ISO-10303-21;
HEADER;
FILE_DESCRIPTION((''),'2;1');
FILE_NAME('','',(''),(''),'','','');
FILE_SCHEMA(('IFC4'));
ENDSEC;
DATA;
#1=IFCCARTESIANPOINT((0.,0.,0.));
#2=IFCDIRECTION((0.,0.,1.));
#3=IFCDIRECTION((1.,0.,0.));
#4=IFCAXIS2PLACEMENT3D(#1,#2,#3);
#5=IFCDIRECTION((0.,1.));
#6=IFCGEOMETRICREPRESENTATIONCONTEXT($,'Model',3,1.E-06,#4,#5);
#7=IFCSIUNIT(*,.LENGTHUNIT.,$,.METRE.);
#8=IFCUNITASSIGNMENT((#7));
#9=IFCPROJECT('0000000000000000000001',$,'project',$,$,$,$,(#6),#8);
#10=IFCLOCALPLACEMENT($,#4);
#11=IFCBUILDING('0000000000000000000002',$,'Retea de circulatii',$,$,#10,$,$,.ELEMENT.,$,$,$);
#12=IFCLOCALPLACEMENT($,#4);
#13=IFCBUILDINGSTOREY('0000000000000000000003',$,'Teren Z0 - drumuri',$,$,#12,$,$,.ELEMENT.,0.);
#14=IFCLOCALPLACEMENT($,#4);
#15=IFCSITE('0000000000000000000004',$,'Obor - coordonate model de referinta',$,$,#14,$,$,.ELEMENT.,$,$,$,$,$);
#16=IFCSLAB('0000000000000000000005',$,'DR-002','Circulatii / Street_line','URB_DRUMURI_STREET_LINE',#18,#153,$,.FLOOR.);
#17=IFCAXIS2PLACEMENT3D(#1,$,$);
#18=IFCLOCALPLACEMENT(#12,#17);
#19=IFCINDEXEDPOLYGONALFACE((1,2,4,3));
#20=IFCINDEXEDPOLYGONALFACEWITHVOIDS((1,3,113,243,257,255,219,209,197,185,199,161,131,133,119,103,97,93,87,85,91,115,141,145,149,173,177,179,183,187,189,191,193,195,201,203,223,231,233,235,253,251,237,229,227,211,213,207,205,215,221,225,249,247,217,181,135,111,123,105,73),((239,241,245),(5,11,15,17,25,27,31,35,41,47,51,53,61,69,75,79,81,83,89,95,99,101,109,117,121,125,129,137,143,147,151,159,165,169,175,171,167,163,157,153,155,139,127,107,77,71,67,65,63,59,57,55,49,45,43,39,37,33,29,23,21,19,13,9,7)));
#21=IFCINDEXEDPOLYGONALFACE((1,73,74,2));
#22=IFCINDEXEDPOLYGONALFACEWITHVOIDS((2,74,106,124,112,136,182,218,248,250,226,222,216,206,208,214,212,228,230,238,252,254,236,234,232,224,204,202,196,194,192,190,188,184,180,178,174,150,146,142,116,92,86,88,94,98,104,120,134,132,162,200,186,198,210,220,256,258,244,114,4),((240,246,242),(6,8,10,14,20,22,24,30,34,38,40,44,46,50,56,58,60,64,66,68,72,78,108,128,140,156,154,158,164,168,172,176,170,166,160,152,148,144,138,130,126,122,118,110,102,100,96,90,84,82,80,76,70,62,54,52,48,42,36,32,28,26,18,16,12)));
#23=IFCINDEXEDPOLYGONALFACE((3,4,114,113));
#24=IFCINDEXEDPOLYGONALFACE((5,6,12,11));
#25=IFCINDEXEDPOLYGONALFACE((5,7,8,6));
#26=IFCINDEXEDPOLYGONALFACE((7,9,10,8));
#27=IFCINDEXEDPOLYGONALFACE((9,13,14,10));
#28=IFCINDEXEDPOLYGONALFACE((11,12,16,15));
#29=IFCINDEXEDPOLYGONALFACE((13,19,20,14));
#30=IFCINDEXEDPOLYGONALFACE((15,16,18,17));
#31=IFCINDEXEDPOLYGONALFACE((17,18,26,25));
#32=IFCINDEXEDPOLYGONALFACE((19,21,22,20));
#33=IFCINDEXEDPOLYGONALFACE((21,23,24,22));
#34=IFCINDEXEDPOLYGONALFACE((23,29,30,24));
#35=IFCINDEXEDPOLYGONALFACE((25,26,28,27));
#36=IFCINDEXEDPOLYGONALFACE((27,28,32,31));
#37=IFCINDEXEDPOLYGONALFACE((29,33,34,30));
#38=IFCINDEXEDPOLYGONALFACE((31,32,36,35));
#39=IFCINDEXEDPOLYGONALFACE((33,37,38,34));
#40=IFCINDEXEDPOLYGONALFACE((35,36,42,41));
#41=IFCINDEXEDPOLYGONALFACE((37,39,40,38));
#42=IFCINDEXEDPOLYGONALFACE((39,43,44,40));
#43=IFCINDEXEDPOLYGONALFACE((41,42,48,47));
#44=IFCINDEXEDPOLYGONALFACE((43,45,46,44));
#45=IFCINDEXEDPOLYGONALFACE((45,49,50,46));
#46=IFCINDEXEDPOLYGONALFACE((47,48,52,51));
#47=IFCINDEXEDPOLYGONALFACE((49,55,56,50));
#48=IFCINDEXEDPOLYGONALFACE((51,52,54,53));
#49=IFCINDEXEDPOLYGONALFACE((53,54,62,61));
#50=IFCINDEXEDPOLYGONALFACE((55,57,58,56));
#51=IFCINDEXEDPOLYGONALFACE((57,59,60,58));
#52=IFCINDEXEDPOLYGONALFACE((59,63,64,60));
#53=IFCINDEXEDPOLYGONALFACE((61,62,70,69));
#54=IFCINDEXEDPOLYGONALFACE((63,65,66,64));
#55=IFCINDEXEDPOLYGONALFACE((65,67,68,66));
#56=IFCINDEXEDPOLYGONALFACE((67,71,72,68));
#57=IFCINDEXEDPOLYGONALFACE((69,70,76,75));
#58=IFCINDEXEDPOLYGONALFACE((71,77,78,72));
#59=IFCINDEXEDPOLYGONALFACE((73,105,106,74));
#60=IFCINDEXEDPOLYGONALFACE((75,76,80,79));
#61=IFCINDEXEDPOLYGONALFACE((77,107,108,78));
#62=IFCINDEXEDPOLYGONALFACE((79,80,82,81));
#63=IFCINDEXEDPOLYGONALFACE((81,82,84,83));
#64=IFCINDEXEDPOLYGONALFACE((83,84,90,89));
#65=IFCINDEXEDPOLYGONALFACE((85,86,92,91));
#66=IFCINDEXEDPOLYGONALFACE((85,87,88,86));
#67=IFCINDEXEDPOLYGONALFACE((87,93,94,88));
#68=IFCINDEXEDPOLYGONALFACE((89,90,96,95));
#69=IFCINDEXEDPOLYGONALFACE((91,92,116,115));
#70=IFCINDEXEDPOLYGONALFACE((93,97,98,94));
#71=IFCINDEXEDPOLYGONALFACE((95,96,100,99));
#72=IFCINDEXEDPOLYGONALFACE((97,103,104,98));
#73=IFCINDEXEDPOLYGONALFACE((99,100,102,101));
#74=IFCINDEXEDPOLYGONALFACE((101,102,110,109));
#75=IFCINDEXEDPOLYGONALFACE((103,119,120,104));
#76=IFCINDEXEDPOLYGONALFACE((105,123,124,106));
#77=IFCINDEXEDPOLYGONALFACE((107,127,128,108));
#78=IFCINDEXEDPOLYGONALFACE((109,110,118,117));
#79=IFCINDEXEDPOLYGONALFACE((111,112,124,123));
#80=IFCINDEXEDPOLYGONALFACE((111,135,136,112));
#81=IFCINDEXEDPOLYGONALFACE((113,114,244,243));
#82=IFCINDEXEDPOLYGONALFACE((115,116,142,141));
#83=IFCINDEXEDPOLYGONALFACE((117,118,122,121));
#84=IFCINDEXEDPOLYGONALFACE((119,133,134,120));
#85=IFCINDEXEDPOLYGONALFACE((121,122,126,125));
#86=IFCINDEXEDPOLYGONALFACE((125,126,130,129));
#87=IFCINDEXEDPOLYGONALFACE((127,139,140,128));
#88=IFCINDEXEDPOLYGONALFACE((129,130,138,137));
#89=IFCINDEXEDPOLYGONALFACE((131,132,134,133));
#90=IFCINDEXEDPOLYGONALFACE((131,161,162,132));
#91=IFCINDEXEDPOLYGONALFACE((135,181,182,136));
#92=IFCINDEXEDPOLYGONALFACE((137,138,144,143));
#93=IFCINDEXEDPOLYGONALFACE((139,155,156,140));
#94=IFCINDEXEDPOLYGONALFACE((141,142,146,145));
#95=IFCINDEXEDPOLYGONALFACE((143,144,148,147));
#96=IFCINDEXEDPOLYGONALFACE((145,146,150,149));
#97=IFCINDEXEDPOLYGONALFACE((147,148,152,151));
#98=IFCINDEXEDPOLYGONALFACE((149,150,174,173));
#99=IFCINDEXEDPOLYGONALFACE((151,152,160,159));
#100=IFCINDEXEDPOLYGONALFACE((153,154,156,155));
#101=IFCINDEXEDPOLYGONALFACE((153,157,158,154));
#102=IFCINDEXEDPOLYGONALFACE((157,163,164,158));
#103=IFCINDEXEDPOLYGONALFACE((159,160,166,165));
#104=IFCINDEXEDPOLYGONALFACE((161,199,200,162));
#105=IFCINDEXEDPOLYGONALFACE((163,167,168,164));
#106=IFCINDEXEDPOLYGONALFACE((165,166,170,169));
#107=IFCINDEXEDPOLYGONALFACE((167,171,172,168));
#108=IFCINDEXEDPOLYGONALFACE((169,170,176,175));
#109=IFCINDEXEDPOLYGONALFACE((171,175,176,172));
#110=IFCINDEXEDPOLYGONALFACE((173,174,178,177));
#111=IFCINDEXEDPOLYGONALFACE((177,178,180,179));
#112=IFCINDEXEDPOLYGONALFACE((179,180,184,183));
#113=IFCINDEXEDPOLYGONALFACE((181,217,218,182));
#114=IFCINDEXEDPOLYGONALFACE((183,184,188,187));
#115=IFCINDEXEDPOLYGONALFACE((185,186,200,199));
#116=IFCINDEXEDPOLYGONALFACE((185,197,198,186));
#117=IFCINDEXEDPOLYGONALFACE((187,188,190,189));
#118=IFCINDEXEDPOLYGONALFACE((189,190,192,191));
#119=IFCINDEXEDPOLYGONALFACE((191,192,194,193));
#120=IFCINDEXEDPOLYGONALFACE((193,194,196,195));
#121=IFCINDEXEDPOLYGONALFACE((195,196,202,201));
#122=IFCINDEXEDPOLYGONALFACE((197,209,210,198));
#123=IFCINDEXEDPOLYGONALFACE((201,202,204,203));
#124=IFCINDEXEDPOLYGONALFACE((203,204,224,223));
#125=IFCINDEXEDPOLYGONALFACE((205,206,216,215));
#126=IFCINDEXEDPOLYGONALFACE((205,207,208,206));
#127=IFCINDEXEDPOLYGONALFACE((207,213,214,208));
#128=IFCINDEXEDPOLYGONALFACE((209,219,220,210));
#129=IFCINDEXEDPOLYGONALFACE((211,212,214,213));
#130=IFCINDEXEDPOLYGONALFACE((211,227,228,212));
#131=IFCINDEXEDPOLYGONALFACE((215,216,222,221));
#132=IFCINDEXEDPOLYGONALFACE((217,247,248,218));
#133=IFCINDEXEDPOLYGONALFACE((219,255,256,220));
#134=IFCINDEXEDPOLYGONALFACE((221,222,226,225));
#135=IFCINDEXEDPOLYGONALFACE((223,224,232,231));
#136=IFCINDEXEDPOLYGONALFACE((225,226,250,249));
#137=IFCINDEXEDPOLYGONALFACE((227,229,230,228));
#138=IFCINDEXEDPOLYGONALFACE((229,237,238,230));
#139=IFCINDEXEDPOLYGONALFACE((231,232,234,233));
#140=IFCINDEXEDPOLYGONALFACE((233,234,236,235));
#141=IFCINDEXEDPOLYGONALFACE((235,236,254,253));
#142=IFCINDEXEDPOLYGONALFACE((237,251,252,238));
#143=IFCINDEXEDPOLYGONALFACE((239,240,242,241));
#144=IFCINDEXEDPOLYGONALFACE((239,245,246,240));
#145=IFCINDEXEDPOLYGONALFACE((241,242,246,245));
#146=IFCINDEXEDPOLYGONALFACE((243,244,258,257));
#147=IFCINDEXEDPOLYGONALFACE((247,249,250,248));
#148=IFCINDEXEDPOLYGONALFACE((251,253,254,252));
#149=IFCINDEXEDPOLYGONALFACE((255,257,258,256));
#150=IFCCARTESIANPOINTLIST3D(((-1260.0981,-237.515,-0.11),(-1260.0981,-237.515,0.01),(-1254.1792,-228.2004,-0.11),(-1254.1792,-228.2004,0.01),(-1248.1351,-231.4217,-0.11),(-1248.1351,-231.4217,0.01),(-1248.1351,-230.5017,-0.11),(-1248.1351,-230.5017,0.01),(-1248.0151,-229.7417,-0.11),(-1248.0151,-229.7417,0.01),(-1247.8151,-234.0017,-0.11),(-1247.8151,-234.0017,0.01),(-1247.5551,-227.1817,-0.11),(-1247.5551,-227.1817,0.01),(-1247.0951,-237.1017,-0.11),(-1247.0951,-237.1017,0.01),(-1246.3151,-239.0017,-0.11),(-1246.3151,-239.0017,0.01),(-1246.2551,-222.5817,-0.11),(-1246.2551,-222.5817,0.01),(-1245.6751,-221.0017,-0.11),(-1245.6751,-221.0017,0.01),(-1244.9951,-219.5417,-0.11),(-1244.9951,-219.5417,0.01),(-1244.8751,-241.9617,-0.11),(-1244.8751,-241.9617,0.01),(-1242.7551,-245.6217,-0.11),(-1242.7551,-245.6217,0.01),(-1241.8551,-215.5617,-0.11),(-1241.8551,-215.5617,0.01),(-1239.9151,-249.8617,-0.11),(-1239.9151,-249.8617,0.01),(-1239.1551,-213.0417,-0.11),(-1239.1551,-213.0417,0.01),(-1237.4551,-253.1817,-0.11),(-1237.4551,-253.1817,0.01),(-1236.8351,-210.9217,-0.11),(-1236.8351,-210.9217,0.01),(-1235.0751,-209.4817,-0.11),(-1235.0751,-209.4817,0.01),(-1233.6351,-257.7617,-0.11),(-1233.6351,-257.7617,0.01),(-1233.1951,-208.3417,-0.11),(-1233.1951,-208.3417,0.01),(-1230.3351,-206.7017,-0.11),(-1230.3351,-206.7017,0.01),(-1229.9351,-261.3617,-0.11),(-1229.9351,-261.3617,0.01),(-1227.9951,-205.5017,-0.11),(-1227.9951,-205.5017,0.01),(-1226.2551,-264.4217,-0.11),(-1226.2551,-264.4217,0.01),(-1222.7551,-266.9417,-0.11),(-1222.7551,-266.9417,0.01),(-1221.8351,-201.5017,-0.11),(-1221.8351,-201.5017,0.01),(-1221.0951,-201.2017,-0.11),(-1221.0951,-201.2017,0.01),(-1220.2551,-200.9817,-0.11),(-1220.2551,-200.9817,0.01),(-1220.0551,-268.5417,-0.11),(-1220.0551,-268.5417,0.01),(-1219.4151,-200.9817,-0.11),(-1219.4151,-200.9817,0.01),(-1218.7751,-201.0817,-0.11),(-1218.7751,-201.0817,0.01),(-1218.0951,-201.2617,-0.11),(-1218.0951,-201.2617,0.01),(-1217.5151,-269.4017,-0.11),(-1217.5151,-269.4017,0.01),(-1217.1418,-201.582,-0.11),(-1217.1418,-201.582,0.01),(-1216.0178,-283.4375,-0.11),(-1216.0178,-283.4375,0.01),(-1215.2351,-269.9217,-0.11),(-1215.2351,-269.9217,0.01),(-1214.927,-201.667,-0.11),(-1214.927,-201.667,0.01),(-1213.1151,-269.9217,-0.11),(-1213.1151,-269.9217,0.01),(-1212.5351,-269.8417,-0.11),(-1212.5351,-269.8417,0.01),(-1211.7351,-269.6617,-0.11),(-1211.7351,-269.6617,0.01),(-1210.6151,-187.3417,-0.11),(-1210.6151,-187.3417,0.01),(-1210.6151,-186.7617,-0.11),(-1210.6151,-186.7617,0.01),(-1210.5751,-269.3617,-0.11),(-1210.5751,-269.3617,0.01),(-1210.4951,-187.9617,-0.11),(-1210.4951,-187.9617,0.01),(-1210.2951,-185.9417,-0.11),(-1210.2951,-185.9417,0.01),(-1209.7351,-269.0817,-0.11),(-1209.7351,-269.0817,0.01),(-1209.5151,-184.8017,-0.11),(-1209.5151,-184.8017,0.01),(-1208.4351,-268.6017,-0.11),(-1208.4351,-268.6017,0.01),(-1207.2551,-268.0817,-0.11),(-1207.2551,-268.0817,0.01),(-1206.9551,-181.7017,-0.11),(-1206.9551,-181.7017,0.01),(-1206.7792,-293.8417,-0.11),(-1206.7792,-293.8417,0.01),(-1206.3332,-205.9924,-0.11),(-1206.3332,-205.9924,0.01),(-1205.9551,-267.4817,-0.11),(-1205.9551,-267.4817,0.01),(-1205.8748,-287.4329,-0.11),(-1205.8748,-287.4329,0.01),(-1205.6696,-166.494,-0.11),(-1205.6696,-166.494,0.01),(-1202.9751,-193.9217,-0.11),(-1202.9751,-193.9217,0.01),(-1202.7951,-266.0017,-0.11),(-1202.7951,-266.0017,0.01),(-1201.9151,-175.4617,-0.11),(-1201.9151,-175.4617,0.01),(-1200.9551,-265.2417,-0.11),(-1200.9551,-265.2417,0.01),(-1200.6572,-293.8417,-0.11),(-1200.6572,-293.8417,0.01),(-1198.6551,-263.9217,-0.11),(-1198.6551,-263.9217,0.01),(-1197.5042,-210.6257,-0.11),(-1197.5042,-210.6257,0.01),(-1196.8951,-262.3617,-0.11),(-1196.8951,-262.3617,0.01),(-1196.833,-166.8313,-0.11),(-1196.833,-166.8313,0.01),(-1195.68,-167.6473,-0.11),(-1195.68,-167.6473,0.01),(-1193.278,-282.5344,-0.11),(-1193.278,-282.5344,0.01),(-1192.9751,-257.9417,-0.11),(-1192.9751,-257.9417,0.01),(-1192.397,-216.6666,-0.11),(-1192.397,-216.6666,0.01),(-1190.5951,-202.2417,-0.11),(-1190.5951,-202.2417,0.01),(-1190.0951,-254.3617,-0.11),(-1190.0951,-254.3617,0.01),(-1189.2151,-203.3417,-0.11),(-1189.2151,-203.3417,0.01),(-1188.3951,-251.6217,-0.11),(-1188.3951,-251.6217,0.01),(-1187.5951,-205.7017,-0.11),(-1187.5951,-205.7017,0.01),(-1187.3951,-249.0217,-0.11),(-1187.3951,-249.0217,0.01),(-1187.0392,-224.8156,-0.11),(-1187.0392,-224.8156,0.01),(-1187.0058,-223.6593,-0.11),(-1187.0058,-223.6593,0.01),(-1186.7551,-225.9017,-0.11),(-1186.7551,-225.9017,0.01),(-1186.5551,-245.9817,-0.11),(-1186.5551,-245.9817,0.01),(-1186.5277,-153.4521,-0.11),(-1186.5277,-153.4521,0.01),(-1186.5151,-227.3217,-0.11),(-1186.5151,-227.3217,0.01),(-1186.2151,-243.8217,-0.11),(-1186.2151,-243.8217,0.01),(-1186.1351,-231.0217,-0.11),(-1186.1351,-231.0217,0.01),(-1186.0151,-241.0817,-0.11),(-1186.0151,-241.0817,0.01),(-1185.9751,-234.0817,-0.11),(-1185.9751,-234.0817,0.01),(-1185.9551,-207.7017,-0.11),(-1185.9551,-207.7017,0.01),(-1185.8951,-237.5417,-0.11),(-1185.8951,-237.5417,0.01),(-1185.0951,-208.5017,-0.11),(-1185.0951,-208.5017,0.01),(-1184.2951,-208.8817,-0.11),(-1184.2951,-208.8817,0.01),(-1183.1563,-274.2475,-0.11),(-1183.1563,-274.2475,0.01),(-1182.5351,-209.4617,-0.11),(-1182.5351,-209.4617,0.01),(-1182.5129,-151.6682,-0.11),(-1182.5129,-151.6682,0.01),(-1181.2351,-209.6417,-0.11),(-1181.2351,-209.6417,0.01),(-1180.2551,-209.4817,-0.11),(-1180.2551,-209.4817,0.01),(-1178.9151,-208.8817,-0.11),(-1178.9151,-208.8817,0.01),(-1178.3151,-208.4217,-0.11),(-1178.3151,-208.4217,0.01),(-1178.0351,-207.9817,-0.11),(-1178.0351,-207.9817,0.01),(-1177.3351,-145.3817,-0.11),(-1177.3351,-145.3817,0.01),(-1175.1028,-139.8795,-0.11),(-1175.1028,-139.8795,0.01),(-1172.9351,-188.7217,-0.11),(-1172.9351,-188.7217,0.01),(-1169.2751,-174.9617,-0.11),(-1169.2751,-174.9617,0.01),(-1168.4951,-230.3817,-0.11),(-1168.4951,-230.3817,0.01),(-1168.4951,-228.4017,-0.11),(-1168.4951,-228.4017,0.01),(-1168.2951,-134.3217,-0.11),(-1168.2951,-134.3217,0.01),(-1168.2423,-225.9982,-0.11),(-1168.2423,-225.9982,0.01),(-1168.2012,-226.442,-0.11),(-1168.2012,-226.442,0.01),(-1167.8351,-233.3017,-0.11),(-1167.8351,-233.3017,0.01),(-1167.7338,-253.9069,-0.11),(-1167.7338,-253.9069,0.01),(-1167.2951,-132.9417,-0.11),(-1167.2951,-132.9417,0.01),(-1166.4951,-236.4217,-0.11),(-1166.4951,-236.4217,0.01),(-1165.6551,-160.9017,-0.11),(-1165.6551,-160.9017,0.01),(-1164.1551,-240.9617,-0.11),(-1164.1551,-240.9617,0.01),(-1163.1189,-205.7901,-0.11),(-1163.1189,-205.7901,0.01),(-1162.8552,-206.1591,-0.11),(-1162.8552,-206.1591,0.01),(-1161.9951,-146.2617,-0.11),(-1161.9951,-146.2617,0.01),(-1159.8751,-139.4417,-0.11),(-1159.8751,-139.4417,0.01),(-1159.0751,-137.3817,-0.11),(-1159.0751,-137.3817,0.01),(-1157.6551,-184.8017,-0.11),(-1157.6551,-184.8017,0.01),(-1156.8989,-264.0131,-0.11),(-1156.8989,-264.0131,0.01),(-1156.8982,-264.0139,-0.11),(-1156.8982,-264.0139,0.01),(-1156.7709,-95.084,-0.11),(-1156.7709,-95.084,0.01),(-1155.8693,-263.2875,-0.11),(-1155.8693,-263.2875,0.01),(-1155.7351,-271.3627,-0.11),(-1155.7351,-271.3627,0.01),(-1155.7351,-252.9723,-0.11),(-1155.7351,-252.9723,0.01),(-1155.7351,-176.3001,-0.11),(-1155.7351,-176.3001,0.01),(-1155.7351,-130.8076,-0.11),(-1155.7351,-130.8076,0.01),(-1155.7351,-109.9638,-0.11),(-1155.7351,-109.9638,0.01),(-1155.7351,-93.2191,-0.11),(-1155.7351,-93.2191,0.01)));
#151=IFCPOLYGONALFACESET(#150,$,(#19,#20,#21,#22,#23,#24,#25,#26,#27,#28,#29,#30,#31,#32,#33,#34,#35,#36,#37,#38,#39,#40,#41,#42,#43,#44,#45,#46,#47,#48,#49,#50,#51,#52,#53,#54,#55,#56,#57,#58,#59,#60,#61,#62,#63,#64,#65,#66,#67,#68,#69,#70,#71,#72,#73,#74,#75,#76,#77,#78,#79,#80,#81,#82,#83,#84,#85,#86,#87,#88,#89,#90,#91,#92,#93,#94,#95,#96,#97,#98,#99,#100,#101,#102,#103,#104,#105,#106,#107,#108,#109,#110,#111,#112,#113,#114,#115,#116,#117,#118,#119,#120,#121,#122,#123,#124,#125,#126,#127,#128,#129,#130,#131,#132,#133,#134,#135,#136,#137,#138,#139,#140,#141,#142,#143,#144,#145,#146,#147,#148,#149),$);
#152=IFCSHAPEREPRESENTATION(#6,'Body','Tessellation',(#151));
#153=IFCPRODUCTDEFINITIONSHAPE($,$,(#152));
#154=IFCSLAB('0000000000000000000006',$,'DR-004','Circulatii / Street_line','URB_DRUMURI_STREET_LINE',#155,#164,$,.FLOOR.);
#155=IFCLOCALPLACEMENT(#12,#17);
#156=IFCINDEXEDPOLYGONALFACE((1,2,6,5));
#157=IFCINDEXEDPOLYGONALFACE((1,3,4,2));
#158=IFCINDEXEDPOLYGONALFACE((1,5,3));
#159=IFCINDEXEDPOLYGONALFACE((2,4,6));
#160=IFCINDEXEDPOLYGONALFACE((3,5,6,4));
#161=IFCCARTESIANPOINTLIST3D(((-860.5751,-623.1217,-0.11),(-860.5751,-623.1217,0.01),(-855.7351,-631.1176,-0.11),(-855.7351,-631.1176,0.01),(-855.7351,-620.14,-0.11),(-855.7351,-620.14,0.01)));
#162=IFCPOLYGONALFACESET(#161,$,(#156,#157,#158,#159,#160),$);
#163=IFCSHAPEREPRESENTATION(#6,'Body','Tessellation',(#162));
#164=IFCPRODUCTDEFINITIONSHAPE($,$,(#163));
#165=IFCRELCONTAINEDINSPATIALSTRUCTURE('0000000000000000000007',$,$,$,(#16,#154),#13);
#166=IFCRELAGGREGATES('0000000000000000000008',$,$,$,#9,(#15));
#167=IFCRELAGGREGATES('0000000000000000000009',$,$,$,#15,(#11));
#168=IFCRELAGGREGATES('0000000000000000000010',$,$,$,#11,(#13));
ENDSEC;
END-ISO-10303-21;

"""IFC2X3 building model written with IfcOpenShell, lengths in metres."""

from ifc_helpers import new_model, si_unit, direction, frame, origin_with_axes, place, context, project, spatial, polyline, outline, extrude, element, save


model = new_model("IFC2X3")

# Units and contexts
model_context = context("Model", 3, precision=1e-06, world=origin_with_axes(), true_north=direction((0.0, 1.0)))
ifc_project = project(units=[si_unit("LENGTHUNIT", "METRE")], contexts=[model_context])

# Site, building, storey
site_placement = place(None, origin_with_axes())
site = spatial("IfcSite", under=ifc_project, at=site_placement, Name="Obor - coordonate model de referinta", CompositionType="ELEMENT")
building_placement = place(None, origin_with_axes())
building = spatial("IfcBuilding", under=site, at=building_placement, Name="Retea de circulatii", CompositionType="ELEMENT")
storey_placement = place(None, origin_with_axes())
storey = spatial("IfcBuildingStorey", under=building, at=storey_placement, Name="Teren Z0 - drumuri", CompositionType="ELEMENT", Elevation=0.0)

# Slabs
slab_1_placement = place(None, origin_with_axes())
element("IfcSlab", 1, at=slab_1_placement, inside=storey, Name="DR-002", Description="Circulatii / Street_line", ObjectType="URB_DRUMURI_STREET_LINE", PredefinedType="FLOOR", context=model_context, shape_type="SweptSolid", body=[
    extrude(outline(polyline([(-1216.0178, -283.4375), (-1206.7792, -293.8417), (-1200.6572, -293.8417), (-1205.8748, -287.4329), (-1193.278, -282.5344), (-1183.1563, -274.2475), (-1167.7338, -253.9069), (-1155.7351, -271.3627), (-1155.7351, -252.9723), (-1164.1551, -240.9617), (-1166.4951, -236.4217), (-1167.8351, -233.3017), (-1168.4951, -230.3817), (-1168.4951, -228.4017), (-1168.2012, -226.442), (-1168.2423, -225.9982), (-1163.1189, -205.7901), (-1162.8552, -206.1591), (-1157.6551, -184.8017), (-1155.7351, -176.3001), (-1155.7351, -130.8076), (-1159.0751, -137.3817), (-1159.8751, -139.4417), (-1161.9951, -146.2617), (-1165.6551, -160.9017), (-1169.2751, -174.9617), (-1172.9351, -188.7217), (-1178.0351, -207.9817), (-1178.3151, -208.4217), (-1178.9151, -208.8817), (-1180.2551, -209.4817), (-1181.2351, -209.6417), (-1182.5351, -209.4617), (-1184.2951, -208.8817), (-1185.0951, -208.5017), (-1185.9551, -207.7017), (-1187.5951, -205.7017), (-1189.2151, -203.3417), (-1190.5951, -202.2417), (-1202.9751, -193.9217), (-1210.4951, -187.9617), (-1210.6151, -187.3417), (-1210.6151, -186.7617), (-1210.2951, -185.9417), (-1209.5151, -184.8017), (-1206.9551, -181.7017), (-1201.9151, -175.4617), (-1195.68, -167.6473), (-1196.833, -166.8313), (-1186.5277, -153.4521), (-1175.1028, -139.8795), (-1182.5129, -151.6682), (-1177.3351, -145.3817), (-1168.2951, -134.3217), (-1167.2951, -132.9417), (-1155.7351, -109.9638), (-1155.7351, -93.2191), (-1156.7709, -95.084), (-1205.6696, -166.494), (-1254.1792, -228.2004), (-1260.0981, -237.515), (-1216.0178, -283.4375)]), holes=[polyline([(-1186.0151, -241.0817), (-1186.2151, -243.8217), (-1186.5551, -245.9817), (-1187.3951, -249.0217), (-1188.3951, -251.6217), (-1190.0951, -254.3617), (-1192.9751, -257.9417), (-1196.8951, -262.3617), (-1198.6551, -263.9217), (-1200.9551, -265.2417), (-1200.9551, -265.2417), (-1202.7951, -266.0017), (-1205.9551, -267.4817), (-1207.2551, -268.0817), (-1208.4351, -268.6017), (-1209.7351, -269.0817), (-1210.5751, -269.3617), (-1211.7351, -269.6617), (-1212.5351, -269.8417), (-1213.1151, -269.9217), (-1215.2351, -269.9217), (-1217.5151, -269.4017), (-1220.0551, -268.5417), (-1222.7551, -266.9417), (-1226.2551, -264.4217), (-1229.9351, -261.3617), (-1233.6351, -257.7617), (-1237.4551, -253.1817), (-1239.9151, -249.8617), (-1242.7551, -245.6217), (-1244.8751, -241.9617), (-1246.3151, -239.0017), (-1247.0951, -237.1017), (-1247.8151, -234.0017), (-1248.1351, -231.4217), (-1248.1351, -230.5017), (-1248.0151, -229.7417), (-1247.5551, -227.1817), (-1246.2551, -222.5817), (-1245.6751, -221.0017), (-1244.9951, -219.5417), (-1241.8551, -215.5617), (-1239.1551, -213.0417), (-1236.8351, -210.9217), (-1235.0751, -209.4817), (-1233.1951, -208.3417), (-1230.3351, -206.7017), (-1227.9951, -205.5017), (-1221.8351, -201.5017), (-1221.0951, -201.2017), (-1220.2551, -200.9817), (-1219.4151, -200.9817), (-1218.7751, -201.0817), (-1218.0951, -201.2617), (-1217.1418, -201.582), (-1214.927, -201.667), (-1206.3332, -205.9924), (-1197.5042, -210.6257), (-1192.397, -216.6666), (-1187.0058, -223.6593), (-1187.0392, -224.8156), (-1186.7551, -225.9017), (-1186.5151, -227.3217), (-1186.1351, -231.0217), (-1185.9751, -234.0817), (-1185.8951, -237.5417), (-1186.0151, -241.0817)]), polyline([(-1155.8693, -263.2875), (-1156.8982, -264.0139), (-1156.8989, -264.0131), (-1155.8693, -263.2875)])]), frame((0.0, 0.0, -0.11), z_axis=(0.0, 0.0, 1.0), x_axis=(1.0, 0.0, 0.0)), (0.0, 0.0, 1.0), 0.12),
])
slab_2_placement = place(None, origin_with_axes())
element("IfcSlab", 2, at=slab_2_placement, inside=storey, Name="DR-004", Description="Circulatii / Street_line", ObjectType="URB_DRUMURI_STREET_LINE", PredefinedType="FLOOR", context=model_context, shape_type="SweptSolid", body=[
    extrude(outline(polyline([(-855.7351, -620.14), (-860.5751, -623.1217), (-855.7351, -631.1176), (-855.7351, -620.14)])), frame((0.0, 0.0, -0.11), z_axis=(0.0, 0.0, 1.0), x_axis=(1.0, 0.0, 0.0)), (0.0, 0.0, 1.0), 0.12),
])

save(model, "model.ifc")
